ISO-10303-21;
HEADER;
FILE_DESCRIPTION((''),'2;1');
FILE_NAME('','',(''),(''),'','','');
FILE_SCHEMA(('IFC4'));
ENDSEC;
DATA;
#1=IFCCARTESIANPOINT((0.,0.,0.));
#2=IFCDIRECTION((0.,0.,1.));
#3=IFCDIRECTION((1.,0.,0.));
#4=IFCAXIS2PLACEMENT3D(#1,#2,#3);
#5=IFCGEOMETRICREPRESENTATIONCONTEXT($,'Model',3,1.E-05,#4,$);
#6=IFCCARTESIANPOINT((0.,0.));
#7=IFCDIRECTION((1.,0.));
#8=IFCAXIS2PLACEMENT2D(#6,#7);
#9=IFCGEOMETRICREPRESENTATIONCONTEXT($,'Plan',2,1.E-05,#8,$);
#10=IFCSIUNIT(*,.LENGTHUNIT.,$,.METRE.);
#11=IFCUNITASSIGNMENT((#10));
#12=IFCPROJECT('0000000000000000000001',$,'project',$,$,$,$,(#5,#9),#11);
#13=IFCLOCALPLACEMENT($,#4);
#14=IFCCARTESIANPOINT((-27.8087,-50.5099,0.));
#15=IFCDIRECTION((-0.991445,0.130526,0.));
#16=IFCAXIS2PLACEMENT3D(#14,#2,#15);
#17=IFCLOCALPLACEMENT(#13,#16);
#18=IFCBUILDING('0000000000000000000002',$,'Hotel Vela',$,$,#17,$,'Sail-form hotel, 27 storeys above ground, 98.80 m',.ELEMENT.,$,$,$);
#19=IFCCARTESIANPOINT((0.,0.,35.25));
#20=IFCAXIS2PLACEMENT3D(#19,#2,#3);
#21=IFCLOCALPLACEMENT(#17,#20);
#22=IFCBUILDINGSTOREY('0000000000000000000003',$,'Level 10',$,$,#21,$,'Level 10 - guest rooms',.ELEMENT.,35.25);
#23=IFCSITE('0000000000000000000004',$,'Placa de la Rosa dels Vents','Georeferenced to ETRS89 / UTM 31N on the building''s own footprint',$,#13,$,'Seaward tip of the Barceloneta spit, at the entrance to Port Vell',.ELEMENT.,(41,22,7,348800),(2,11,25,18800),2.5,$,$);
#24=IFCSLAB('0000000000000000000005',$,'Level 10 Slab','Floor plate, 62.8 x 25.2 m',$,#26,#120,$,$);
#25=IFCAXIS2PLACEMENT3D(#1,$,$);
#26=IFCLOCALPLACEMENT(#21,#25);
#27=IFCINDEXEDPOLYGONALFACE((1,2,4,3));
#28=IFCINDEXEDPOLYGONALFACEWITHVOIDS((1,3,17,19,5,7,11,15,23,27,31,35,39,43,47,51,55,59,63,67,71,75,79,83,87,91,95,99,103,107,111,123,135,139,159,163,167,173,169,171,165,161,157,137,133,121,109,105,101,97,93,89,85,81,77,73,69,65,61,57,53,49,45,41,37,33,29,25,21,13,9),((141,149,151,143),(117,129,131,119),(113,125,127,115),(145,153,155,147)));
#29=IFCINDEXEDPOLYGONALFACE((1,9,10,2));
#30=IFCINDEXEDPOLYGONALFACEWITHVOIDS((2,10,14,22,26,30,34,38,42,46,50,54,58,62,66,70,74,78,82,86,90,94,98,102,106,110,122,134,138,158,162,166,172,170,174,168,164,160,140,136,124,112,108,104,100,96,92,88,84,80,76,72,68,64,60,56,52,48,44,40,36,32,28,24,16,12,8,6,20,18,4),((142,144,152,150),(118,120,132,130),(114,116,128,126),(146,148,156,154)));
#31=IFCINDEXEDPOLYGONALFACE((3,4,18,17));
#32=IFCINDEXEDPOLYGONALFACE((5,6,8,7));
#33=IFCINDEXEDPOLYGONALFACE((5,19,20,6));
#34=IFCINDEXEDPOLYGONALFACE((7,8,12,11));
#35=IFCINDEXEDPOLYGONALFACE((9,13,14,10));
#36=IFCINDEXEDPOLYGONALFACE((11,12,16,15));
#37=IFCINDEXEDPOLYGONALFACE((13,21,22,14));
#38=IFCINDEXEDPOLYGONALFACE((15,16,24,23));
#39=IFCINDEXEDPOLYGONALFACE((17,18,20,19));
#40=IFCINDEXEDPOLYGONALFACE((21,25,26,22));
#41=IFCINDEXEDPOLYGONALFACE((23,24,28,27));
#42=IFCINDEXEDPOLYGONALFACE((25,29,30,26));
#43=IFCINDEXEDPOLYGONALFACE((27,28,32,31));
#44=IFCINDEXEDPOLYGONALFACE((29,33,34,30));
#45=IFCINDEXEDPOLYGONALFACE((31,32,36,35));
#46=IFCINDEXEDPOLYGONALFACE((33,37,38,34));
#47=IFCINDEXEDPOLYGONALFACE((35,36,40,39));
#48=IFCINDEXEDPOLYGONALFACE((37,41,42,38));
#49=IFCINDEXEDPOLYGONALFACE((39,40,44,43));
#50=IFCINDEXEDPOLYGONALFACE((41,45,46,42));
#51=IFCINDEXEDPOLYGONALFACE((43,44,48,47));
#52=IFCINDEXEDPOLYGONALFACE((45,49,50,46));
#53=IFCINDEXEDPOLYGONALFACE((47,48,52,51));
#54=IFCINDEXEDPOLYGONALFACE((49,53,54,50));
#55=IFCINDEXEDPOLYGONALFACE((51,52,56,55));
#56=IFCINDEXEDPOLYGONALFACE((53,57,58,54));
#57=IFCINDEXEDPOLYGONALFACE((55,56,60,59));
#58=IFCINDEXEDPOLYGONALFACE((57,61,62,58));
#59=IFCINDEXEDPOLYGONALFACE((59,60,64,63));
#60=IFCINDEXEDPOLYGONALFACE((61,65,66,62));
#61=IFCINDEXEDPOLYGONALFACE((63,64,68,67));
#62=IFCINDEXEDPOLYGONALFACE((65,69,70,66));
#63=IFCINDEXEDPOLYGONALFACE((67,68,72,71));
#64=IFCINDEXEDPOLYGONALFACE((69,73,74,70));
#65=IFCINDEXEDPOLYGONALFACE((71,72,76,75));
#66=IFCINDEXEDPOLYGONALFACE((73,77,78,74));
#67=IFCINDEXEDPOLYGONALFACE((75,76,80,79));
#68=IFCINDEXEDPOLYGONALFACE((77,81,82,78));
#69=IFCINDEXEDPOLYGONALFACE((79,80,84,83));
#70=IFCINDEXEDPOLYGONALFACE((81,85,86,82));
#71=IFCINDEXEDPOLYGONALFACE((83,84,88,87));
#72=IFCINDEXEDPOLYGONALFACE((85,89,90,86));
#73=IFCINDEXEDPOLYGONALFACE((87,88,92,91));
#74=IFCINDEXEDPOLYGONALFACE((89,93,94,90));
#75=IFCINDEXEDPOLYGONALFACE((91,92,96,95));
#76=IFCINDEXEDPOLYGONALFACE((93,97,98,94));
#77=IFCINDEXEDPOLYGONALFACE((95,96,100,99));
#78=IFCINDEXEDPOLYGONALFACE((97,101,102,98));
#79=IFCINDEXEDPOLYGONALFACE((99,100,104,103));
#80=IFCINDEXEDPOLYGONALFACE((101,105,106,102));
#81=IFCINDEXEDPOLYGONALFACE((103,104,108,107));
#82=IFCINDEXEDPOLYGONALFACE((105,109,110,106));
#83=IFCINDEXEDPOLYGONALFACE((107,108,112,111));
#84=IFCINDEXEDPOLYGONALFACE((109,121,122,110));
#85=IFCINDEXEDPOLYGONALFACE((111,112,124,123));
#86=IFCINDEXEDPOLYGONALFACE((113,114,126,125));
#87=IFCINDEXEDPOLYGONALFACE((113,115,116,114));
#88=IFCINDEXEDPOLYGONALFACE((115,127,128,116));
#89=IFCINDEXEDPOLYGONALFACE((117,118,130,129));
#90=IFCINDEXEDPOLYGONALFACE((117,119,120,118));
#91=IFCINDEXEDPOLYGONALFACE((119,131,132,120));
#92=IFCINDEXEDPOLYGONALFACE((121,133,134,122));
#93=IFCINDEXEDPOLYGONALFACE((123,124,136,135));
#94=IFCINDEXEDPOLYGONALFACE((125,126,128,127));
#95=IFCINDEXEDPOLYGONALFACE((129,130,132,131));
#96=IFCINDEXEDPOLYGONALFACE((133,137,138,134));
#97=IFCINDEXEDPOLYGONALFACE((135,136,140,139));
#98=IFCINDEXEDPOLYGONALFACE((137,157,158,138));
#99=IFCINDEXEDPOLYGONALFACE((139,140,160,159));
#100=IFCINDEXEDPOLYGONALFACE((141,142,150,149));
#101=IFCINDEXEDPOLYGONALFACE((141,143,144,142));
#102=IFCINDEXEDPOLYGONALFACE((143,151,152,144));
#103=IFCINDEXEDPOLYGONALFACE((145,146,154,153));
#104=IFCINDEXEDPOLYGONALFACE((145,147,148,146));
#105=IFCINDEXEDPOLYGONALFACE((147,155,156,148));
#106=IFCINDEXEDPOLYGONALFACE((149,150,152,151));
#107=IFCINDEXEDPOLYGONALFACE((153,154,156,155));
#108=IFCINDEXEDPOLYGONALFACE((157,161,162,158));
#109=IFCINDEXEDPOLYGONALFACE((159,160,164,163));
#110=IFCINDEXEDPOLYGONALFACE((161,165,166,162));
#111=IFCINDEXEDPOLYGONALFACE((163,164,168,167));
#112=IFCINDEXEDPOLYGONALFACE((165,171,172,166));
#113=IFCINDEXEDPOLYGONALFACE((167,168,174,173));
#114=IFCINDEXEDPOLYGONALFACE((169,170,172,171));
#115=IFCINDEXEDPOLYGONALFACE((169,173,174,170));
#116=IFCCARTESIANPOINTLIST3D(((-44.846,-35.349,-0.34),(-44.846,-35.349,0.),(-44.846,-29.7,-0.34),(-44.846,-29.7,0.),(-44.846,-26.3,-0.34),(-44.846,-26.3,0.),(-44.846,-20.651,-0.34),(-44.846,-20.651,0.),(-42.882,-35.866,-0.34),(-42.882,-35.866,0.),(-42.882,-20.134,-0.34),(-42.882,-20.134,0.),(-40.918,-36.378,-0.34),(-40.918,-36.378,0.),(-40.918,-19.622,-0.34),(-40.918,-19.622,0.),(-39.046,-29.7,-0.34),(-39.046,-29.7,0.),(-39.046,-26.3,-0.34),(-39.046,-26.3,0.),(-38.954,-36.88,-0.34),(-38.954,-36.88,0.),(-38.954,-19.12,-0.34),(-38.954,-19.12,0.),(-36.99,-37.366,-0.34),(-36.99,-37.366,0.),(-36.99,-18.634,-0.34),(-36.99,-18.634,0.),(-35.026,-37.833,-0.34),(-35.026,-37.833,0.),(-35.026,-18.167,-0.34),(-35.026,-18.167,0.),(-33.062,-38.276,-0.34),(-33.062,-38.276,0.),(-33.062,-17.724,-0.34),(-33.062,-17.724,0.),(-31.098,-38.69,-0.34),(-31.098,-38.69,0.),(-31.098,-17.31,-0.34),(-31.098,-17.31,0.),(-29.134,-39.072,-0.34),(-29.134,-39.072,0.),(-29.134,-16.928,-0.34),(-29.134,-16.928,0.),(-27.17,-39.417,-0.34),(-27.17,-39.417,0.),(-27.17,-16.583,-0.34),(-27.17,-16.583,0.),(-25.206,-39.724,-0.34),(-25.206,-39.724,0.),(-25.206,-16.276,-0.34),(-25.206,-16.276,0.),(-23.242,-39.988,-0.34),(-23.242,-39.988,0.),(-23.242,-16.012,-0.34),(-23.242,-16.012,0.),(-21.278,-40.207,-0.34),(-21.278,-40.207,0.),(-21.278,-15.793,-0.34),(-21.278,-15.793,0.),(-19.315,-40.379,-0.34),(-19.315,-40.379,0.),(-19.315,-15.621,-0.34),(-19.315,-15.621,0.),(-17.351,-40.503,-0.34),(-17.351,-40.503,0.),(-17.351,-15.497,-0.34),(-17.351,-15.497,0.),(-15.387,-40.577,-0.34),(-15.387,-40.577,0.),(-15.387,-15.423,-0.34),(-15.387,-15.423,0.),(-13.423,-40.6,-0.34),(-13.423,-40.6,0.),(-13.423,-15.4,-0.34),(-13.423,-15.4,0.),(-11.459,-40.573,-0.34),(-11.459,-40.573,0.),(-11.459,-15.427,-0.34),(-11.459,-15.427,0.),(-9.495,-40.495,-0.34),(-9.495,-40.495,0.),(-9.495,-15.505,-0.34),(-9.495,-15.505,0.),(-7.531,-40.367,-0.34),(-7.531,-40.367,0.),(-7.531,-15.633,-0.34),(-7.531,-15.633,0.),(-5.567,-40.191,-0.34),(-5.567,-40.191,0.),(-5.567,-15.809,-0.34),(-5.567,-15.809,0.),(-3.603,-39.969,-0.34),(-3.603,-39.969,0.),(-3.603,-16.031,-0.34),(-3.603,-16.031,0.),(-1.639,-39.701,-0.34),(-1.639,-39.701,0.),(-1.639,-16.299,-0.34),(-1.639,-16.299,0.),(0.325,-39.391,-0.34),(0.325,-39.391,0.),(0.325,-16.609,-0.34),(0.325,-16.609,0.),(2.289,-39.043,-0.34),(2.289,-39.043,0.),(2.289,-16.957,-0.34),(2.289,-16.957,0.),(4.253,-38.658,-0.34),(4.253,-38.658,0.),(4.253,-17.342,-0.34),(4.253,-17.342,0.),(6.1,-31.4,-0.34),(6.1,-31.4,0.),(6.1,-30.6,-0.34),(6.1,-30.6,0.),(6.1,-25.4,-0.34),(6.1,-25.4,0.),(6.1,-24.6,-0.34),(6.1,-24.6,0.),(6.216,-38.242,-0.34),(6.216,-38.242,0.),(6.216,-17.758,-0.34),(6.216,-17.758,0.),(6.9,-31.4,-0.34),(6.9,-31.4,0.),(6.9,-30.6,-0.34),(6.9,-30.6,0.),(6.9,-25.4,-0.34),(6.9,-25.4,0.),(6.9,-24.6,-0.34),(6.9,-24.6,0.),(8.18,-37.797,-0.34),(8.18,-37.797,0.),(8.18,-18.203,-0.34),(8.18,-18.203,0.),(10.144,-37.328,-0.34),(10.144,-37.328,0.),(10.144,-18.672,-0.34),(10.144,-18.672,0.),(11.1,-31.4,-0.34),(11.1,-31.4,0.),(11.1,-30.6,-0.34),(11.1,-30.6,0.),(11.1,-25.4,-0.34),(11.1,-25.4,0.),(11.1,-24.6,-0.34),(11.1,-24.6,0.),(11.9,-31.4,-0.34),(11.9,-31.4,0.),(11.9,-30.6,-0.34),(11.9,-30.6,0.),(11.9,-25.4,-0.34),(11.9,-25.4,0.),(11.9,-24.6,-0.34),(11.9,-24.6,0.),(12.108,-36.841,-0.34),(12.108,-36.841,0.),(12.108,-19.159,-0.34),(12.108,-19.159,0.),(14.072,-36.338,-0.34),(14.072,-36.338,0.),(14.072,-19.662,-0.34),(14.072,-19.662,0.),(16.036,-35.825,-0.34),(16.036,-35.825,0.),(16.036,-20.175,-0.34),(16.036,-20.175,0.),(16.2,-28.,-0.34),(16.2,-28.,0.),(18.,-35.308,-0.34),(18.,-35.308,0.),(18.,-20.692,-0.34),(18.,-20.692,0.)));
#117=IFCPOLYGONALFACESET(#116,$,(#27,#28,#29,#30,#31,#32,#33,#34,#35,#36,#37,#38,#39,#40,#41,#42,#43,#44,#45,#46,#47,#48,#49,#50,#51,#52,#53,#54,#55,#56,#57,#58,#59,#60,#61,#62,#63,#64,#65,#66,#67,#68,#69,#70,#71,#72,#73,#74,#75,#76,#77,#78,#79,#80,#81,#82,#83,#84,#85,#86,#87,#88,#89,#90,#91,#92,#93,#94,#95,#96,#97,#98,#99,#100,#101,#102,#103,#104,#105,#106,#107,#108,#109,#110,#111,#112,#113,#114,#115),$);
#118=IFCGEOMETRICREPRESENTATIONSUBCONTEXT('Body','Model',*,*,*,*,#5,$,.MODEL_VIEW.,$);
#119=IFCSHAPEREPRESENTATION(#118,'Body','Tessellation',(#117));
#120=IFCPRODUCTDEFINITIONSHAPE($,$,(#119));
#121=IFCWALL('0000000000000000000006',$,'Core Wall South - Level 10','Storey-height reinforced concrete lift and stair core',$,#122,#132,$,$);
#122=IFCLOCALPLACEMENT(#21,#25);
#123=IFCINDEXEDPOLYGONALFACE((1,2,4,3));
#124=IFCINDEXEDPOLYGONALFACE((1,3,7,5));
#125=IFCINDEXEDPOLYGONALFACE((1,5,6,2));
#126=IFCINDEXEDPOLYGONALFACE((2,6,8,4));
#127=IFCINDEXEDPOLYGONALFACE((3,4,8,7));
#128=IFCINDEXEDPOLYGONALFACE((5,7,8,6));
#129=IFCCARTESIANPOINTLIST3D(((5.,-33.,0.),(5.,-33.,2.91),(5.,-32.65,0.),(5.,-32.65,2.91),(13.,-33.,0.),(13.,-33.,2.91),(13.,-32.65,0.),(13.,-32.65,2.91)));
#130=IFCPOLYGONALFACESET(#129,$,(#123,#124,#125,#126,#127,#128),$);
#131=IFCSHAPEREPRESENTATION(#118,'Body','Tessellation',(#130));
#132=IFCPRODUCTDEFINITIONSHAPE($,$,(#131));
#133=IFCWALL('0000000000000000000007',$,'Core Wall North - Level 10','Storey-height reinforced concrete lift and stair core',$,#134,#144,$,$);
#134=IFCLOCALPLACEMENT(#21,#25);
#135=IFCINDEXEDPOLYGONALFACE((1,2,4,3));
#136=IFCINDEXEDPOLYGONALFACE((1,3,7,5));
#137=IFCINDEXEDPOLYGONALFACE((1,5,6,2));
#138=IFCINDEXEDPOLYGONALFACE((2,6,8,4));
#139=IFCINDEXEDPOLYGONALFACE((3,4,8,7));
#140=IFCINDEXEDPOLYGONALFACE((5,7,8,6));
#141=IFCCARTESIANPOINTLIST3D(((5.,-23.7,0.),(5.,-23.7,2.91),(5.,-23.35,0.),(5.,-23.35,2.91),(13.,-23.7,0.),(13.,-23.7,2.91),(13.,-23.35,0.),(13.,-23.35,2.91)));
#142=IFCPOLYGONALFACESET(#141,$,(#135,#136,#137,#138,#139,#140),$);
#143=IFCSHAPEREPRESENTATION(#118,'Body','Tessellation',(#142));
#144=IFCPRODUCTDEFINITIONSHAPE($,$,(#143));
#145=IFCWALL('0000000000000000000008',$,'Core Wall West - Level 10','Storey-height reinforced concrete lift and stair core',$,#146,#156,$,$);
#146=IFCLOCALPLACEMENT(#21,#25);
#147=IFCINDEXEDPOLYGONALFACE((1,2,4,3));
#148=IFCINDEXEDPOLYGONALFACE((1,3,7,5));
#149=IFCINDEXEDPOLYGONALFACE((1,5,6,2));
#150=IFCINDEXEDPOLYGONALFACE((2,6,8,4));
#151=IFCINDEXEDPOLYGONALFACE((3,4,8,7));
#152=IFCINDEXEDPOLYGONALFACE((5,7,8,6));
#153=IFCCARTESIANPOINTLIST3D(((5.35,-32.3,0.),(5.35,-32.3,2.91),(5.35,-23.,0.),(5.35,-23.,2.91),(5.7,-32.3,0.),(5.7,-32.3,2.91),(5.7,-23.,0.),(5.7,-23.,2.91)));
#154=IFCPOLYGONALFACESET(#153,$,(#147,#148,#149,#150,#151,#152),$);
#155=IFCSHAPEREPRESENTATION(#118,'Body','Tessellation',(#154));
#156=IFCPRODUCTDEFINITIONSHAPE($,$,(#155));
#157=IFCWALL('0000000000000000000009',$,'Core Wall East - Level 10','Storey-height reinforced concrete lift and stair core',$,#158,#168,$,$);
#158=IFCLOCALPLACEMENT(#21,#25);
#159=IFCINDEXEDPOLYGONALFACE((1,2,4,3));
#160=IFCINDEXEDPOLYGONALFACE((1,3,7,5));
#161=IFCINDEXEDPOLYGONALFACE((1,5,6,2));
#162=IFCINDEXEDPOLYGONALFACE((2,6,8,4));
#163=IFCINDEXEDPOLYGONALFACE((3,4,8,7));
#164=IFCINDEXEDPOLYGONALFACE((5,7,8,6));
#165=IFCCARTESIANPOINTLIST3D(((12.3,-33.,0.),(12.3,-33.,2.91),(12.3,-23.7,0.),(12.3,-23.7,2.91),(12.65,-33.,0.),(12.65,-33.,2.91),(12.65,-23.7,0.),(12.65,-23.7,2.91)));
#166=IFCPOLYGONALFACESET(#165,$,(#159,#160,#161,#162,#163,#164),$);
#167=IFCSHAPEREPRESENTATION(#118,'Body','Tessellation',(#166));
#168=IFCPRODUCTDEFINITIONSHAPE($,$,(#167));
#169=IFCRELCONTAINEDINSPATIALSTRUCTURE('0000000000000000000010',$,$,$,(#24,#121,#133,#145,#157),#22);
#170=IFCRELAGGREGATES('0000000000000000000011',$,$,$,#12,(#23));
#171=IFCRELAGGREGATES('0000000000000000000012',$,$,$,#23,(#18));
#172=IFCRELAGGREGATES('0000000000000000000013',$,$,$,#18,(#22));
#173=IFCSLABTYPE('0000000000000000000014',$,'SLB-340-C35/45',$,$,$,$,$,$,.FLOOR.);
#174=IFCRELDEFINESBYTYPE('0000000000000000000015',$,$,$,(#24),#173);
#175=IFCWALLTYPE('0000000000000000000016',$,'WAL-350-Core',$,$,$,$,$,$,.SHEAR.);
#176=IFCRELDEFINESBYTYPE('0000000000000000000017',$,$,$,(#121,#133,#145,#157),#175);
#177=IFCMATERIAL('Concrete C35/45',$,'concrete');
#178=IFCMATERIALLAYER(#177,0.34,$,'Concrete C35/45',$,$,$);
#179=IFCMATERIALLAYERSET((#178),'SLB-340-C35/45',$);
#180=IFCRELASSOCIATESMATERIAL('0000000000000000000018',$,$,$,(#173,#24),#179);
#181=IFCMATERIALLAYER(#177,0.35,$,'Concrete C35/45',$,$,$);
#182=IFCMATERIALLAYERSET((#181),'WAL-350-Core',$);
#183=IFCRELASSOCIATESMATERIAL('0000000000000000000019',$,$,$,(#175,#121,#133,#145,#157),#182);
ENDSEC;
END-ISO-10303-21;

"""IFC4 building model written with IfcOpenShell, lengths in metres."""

from ifc_helpers import new_model, si_unit, frame, origin_with_axes, origin_2d_with_axis, place, context, subcontext, project, spatial, line, indexed_curve, outline, extrude, material, layer, layer_set, layer_usage, type_object, element, save


model = new_model("IFC4")

# Units and contexts
model_context = context("Model", 3, precision=1e-05, world=origin_with_axes())
plan_context = context("Plan", 2, precision=1e-05, world=origin_2d_with_axis())
body_context = subcontext(model_context, "Body", "Model", "MODEL_VIEW")
ifc_project = project(units=[si_unit("LENGTHUNIT", "METRE")], contexts=[model_context, plan_context])

# Site, building, storey
site_placement = place(None, origin_with_axes())
site = spatial("IfcSite", under=ifc_project, at=site_placement, Name="Placa de la Rosa dels Vents", Description="Georeferenced to ETRS89 / UTM 31N on the building's own footprint", LongName="Seaward tip of the Barceloneta spit, at the entrance to Port Vell", CompositionType="ELEMENT", RefLatitude=(41, 22, 7, 348800), RefLongitude=(2, 11, 25, 18800), RefElevation=2.5)
building_placement = place(site_placement, frame((-27.8087, -50.5099, 0.0), z_axis=(0.0, 0.0, 1.0), x_axis=(-0.991445, 0.130526, 0.0)))
building = spatial("IfcBuilding", under=site, at=building_placement, Name="Hotel Vela", LongName="Sail-form hotel, 27 storeys above ground, 98.80 m", CompositionType="ELEMENT")
storey_placement = place(building_placement, frame((0.0, 0.0, 35.25), z_axis=(0.0, 0.0, 1.0), x_axis=(1.0, 0.0, 0.0)))
storey = spatial("IfcBuildingStorey", under=building, at=storey_placement, Name="Level 10", LongName="Level 10 - guest rooms", CompositionType="ELEMENT", Elevation=35.25)

# Shared definitions
ifc_material = material(Name="Concrete C35/45", Category="concrete")

# Slab, openings
ifc_layer_1 = layer(ifc_material, 0.34, Name="Concrete C35/45")
ifc_layer_set_1 = layer_set([ifc_layer_1], Name="SLB-340-C35/45")
ifc_layer_usage_1 = layer_usage(ifc_layer_set_1, "AXIS3", "POSITIVE", 0.0)
slab_type = type_object("IfcSlabType", Name="SLB-340-C35/45", PredefinedType="FLOOR", material=ifc_layer_set_1)
slab_placement = place(storey_placement, frame((0.0, 0.0, -0.34), z_axis=(0.0, 0.0, 1.0), x_axis=(1.0, 0.0, 0.0)))
slab = element("IfcSlab", 1, at=slab_placement, inside=storey, type_object=slab_type, material=ifc_layer_usage_1, Name="Level 10 Slab", Description="Floor plate, 62.8 x 25.2 m", context=body_context, shape_type="SweptSolid", body=[
    extrude(outline(indexed_curve([(-44.846, -35.349), (-42.882, -35.866), (-40.918, -36.378), (-38.954, -36.88), (-36.99, -37.366), (-35.026, -37.833), (-33.062, -38.276), (-31.098, -38.69), (-29.134, -39.072), (-27.17, -39.417), (-25.206, -39.724), (-23.242, -39.988), (-21.278, -40.207), (-19.315, -40.379), (-17.351, -40.503), (-15.387, -40.577), (-13.423, -40.6), (-11.459, -40.573), (-9.495, -40.495), (-7.531, -40.367), (-5.567, -40.191), (-3.603, -39.969), (-1.639, -39.701), (0.325, -39.391), (2.289, -39.043), (4.253, -38.658), (6.216, -38.242), (8.18, -37.797), (10.144, -37.328), (12.108, -36.841), (14.072, -36.338), (16.036, -35.825), (18.0, -35.308), (16.2, -28.0), (18.0, -20.692), (16.036, -20.175), (14.072, -19.662), (12.108, -19.159), (10.144, -18.672), (8.18, -18.203), (6.216, -17.758), (4.253, -17.342), (2.289, -16.957), (0.325, -16.609), (-1.639, -16.299), (-3.603, -16.031), (-5.567, -15.809), (-7.531, -15.633), (-9.495, -15.505), (-11.459, -15.427), (-13.423, -15.4), (-15.387, -15.423), (-17.351, -15.497), (-19.315, -15.621), (-21.278, -15.793), (-23.242, -16.012), (-25.206, -16.276), (-27.17, -16.583), (-29.134, -16.928), (-31.098, -17.31), (-33.062, -17.724), (-35.026, -18.167), (-36.99, -18.634), (-38.954, -19.12), (-40.918, -19.622), (-42.882, -20.134), (-44.846, -20.651), (-44.846, -26.3), (-39.046, -26.3), (-39.046, -29.7), (-44.846, -29.7)], segments=[line(1, 2, 3, 4, 5, 6, 7, 8, 9, 10, 11, 12, 13, 14, 15, 16, 17, 18, 19, 20, 21, 22, 23, 24, 25, 26, 27, 28, 29, 30, 31, 32, 33, 34, 35, 36, 37, 38, 39, 40, 41, 42, 43, 44, 45, 46, 47, 48, 49, 50, 51, 52, 53, 54, 55, 56, 57, 58, 59, 60, 61, 62, 63, 64, 65, 66, 67, 68, 69, 70, 71, 1)])), origin_with_axes(), (0.0, 0.0, 1.0), 0.34),
])
opening_1_placement = place(slab_placement, frame((6.1, -31.4, -0.05), z_axis=(0.0, 0.0, 1.0), x_axis=(1.0, 0.0, 0.0)))
element("IfcOpeningElement", 2, at=opening_1_placement, cuts=slab, PredefinedType="OPENING", context=body_context, shape_type="SweptSolid", body=[
    extrude(outline(indexed_curve([(0.0, 0.0), (0.8, 0.0), (0.8, 0.8), (0.0, 0.8)], segments=[line(1, 2, 3, 4, 1)])), origin_with_axes(), (0.0, 0.0, 1.0), 0.44),
])
opening_2_placement = place(slab_placement, frame((6.1, -25.4, -0.05), z_axis=(0.0, 0.0, 1.0), x_axis=(1.0, 0.0, 0.0)))
element("IfcOpeningElement", 3, at=opening_2_placement, cuts=slab, PredefinedType="OPENING", context=body_context, shape_type="SweptSolid", body=[
    extrude(outline(indexed_curve([(0.0, 0.0), (0.8, 0.0), (0.8, 0.8), (0.0, 0.8)], segments=[line(1, 2, 3, 4, 1)])), origin_with_axes(), (0.0, 0.0, 1.0), 0.44),
])
opening_3_placement = place(slab_placement, frame((11.1, -31.4, -0.05), z_axis=(0.0, 0.0, 1.0), x_axis=(1.0, 0.0, 0.0)))
element("IfcOpeningElement", 4, at=opening_3_placement, cuts=slab, PredefinedType="OPENING", context=body_context, shape_type="SweptSolid", body=[
    extrude(outline(indexed_curve([(0.0, 0.0), (0.8, 0.0), (0.8, 0.8), (0.0, 0.8)], segments=[line(1, 2, 3, 4, 1)])), origin_with_axes(), (0.0, 0.0, 1.0), 0.44),
])
opening_4_placement = place(slab_placement, frame((11.1, -25.4, -0.05), z_axis=(0.0, 0.0, 1.0), x_axis=(1.0, 0.0, 0.0)))
element("IfcOpeningElement", 5, at=opening_4_placement, cuts=slab, PredefinedType="OPENING", context=body_context, shape_type="SweptSolid", body=[
    extrude(outline(indexed_curve([(0.0, 0.0), (0.8, 0.0), (0.8, 0.8), (0.0, 0.8)], segments=[line(1, 2, 3, 4, 1)])), origin_with_axes(), (0.0, 0.0, 1.0), 0.44),
])

# Walls
ifc_layer_2 = layer(ifc_material, 0.35, Name="Concrete C35/45")
ifc_layer_set_2 = layer_set([ifc_layer_2], Name="WAL-350-Core")
ifc_layer_usage_2 = layer_usage(ifc_layer_set_2, "AXIS2", "POSITIVE", 0.0)
wall_type = type_object("IfcWallType", Name="WAL-350-Core", PredefinedType="SHEAR", material=ifc_layer_set_2)
wall_1_placement = place(storey_placement, frame((5.0, -33.0, 0.0), z_axis=(0.0, 0.0, 1.0), x_axis=(1.0, 0.0, 0.0)))
element("IfcWall", 6, at=wall_1_placement, inside=storey, type_object=wall_type, material=ifc_layer_usage_2, Name="Core Wall South - Level 10", Description="Storey-height reinforced concrete lift and stair core", context=body_context, shape_type="SweptSolid", body=[
    extrude(outline(indexed_curve([(0.0, 0.0), (8.0, 0.0), (8.0, 0.35), (0.0, 0.35)], segments=[line(1, 2, 3, 4, 1)])), origin_with_axes(), (0.0, 0.0, 1.0), 2.91),
])
ifc_layer_usage_3 = layer_usage(ifc_layer_set_2, "AXIS2", "POSITIVE", 0.0)
wall_2_placement = place(storey_placement, frame((13.0, -23.35, 0.0), z_axis=(0.0, 0.0, 1.0), x_axis=(-1.0, 0.0, 0.0)))
element("IfcWall", 7, at=wall_2_placement, inside=storey, type_object=wall_type, material=ifc_layer_usage_3, Name="Core Wall North - Level 10", Description="Storey-height reinforced concrete lift and stair core", context=body_context, shape_type="SweptSolid", body=[
    extrude(outline(indexed_curve([(0.0, 0.0), (8.0, 0.0), (8.0, 0.35), (0.0, 0.35)], segments=[line(1, 2, 3, 4, 1)])), origin_with_axes(), (0.0, 0.0, 1.0), 2.91),
])
ifc_layer_usage_4 = layer_usage(ifc_layer_set_2, "AXIS2", "POSITIVE", 0.0)
wall_3_placement = place(storey_placement, frame((5.35, -23.0, 0.0), z_axis=(0.0, 0.0, 1.0), x_axis=(0.0, -1.0, 0.0)))
element("IfcWall", 8, at=wall_3_placement, inside=storey, type_object=wall_type, material=ifc_layer_usage_4, Name="Core Wall West - Level 10", Description="Storey-height reinforced concrete lift and stair core", context=body_context, shape_type="SweptSolid", body=[
    extrude(outline(indexed_curve([(0.0, 0.0), (9.3, 0.0), (9.3, 0.35), (0.0, 0.35)], segments=[line(1, 2, 3, 4, 1)])), origin_with_axes(), (0.0, 0.0, 1.0), 2.91),
])
ifc_layer_usage_5 = layer_usage(ifc_layer_set_2, "AXIS2", "POSITIVE", 0.0)
wall_4_placement = place(storey_placement, frame((12.65, -33.0, 0.0), z_axis=(0.0, 0.0, 1.0), x_axis=(0.0, 1.0, 0.0)))
element("IfcWall", 9, at=wall_4_placement, inside=storey, type_object=wall_type, material=ifc_layer_usage_5, Name="Core Wall East - Level 10", Description="Storey-height reinforced concrete lift and stair core", context=body_context, shape_type="SweptSolid", body=[
    extrude(outline(indexed_curve([(0.0, 0.0), (9.3, 0.0), (9.3, 0.35), (0.0, 0.35)], segments=[line(1, 2, 3, 4, 1)])), origin_with_axes(), (0.0, 0.0, 1.0), 2.91),
])

save(model, "model.ifc")
